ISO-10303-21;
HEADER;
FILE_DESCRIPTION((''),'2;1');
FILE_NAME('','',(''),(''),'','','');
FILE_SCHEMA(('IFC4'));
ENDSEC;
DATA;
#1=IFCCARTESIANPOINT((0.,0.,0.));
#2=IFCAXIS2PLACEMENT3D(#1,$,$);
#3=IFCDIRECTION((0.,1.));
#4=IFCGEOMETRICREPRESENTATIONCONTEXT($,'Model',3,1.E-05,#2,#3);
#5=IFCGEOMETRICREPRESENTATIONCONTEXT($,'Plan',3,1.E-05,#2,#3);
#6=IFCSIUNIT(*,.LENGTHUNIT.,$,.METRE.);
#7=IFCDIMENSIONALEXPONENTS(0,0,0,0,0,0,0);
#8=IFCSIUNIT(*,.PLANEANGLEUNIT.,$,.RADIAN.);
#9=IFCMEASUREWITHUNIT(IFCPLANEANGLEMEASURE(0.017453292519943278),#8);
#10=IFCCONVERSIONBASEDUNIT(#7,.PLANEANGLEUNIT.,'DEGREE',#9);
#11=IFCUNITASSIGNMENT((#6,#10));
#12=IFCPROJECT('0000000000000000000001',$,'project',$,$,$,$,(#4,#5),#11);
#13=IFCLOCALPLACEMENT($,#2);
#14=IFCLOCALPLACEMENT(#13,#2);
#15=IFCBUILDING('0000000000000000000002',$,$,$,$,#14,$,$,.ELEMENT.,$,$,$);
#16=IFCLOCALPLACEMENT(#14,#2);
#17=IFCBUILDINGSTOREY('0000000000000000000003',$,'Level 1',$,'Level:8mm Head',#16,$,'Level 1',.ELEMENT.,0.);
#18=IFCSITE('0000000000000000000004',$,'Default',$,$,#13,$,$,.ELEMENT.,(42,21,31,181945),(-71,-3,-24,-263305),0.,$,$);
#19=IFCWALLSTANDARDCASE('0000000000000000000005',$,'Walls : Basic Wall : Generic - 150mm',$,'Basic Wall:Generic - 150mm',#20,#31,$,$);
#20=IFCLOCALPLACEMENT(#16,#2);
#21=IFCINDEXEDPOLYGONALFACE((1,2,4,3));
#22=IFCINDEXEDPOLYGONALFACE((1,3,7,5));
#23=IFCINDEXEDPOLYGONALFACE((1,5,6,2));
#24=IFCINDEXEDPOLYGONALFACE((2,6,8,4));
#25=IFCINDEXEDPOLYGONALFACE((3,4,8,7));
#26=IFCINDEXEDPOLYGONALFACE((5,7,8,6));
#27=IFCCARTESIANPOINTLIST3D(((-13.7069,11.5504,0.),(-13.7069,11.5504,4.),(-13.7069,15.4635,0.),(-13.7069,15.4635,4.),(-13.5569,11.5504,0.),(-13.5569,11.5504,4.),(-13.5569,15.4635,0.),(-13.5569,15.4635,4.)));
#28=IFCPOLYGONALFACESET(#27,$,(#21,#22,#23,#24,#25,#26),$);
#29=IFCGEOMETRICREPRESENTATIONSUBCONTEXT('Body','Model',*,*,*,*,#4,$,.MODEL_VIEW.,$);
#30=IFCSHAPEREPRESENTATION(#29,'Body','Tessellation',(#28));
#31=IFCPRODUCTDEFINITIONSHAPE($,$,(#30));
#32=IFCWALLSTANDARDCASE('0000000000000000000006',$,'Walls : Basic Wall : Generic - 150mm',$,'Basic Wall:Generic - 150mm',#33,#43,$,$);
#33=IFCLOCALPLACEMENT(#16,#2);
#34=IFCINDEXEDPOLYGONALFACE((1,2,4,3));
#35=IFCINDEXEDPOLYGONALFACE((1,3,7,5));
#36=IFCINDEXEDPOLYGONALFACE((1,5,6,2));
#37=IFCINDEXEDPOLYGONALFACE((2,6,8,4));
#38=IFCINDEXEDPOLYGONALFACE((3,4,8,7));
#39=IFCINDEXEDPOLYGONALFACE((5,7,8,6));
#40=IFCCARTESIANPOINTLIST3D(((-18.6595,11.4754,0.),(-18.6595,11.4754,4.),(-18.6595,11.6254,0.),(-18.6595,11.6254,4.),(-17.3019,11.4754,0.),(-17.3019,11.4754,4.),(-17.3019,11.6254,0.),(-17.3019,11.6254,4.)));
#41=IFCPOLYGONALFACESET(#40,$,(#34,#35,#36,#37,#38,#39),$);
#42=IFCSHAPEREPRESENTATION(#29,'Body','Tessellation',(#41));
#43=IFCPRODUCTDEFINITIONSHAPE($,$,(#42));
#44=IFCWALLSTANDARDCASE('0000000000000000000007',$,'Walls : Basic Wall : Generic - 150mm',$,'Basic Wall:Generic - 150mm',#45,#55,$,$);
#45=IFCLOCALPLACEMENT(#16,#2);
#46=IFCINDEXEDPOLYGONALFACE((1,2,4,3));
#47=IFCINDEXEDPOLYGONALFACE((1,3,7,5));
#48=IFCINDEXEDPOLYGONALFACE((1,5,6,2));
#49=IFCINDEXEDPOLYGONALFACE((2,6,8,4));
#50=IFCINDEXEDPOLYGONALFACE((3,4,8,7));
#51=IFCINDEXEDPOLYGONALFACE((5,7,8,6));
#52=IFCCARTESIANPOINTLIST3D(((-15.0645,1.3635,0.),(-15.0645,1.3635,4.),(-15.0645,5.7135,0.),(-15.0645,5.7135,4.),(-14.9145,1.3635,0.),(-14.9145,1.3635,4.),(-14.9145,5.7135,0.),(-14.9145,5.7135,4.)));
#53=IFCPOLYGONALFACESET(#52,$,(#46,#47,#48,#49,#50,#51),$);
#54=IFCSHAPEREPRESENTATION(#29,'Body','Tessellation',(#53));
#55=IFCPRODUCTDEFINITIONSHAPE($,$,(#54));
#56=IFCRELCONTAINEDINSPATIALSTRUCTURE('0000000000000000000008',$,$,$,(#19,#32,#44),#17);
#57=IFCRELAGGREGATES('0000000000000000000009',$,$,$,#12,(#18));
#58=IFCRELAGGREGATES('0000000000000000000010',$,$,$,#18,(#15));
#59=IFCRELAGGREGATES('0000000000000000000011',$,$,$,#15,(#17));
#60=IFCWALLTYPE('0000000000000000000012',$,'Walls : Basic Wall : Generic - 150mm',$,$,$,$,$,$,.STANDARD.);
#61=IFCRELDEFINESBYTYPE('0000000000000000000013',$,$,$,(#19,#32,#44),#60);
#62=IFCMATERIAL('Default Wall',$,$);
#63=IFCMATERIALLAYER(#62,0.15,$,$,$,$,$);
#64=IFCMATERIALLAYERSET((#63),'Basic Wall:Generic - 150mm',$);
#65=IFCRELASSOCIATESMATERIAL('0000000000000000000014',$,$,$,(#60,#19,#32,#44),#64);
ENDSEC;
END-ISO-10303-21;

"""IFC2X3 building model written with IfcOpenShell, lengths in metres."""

from ifc_helpers import new_model, entity, si_unit, converted_unit, direction, frame, frame_2d, origin, place, context, subcontext, project, spatial, rectangle, extrude, material, layer, layer_set, layer_usage, type_object, element, save


model = new_model("IFC2X3")

# Units and contexts
model_context = context("Model", 3, precision=1e-05, world=origin(), true_north=direction((0.0, 1.0)))
plan_context = context("Plan", 3, precision=1e-05, world=origin(), true_north=direction((0.0, 1.0)))
body_context = subcontext(model_context, "Body", "Model", "MODEL_VIEW")
ifc_project = project(units=[si_unit("LENGTHUNIT", "METRE"), converted_unit("PLANEANGLEUNIT", "DEGREE", entity("IfcPlaneAngleMeasure", 0.017453292519943278), si_unit("PLANEANGLEUNIT", "RADIAN"), dimensions=[0, 0, 0, 0, 0, 0, 0])], contexts=[model_context, plan_context])

# Site, building, storey
site_placement = place(None, origin())
site = spatial("IfcSite", under=ifc_project, at=site_placement, Name="Default", CompositionType="ELEMENT", RefLatitude=(42, 21, 31, 181945), RefLongitude=(-71, -3, -24, -263305), RefElevation=0.0)
building_placement = place(site_placement, origin())
building = spatial("IfcBuilding", under=site, at=building_placement, CompositionType="ELEMENT")
storey_placement = place(building_placement, origin())
storey = spatial("IfcBuildingStorey", under=building, at=storey_placement, Name="Level 1", ObjectType="Level:8mm Head", LongName="Level 1", CompositionType="ELEMENT", Elevation=0.0)

# Walls
ifc_material = material(Name="Default Wall")
ifc_layer_1 = layer(ifc_material, 0.15)
ifc_layer_set_1 = layer_set([ifc_layer_1], Name="Basic Wall:Generic - 150mm")
ifc_layer_usage_1 = layer_usage(ifc_layer_set_1, "AXIS2", "NEGATIVE", 0.075)
wall_type_1 = type_object("IfcWallType", Name="Walls : Basic Wall : Generic - 150mm", PredefinedType="STANDARD", material=ifc_layer_set_1)
wall_1_placement = place(storey_placement, frame((-13.6319, 11.5504, 0.0), z_axis=(0.0, 0.0, 1.0), x_axis=(0.0, 1.0, 0.0)))
element("IfcWallStandardCase", 1, at=wall_1_placement, inside=storey, type_object=wall_type_1, material=ifc_layer_usage_1, Name="Walls : Basic Wall : Generic - 150mm", ObjectType="Basic Wall:Generic - 150mm", context=body_context, shape_type="SweptSolid", body=[
    extrude(rectangle(XDim=3.9131, YDim=0.15, at=frame_2d((1.9565, 0.0), x_axis=(-1.0, 0.0))), origin(), (0.0, 0.0, 1.0), 4.0),
])
wall_2_placement = place(storey_placement, frame((-18.6595, 11.5504, 0.0)))
element("IfcWallStandardCase", 2, at=wall_2_placement, inside=storey, type_object=wall_type_1, material=ifc_layer_usage_1, Name="Walls : Basic Wall : Generic - 150mm", ObjectType="Basic Wall:Generic - 150mm", context=body_context, shape_type="SweptSolid", body=[
    extrude(rectangle(XDim=1.3576, YDim=0.15, at=frame_2d((0.6788, 0.0), x_axis=(-1.0, 0.0))), origin(), (0.0, 0.0, 1.0), 4.0),
])
wall_3_placement = place(storey_placement, frame((-14.9895, 5.7135, 0.0), z_axis=(0.0, 0.0, 1.0), x_axis=(0.0, -1.0, 0.0)))
element("IfcWallStandardCase", 3, at=wall_3_placement, inside=storey, type_object=wall_type_1, material=ifc_layer_usage_1, Name="Walls : Basic Wall : Generic - 150mm", ObjectType="Basic Wall:Generic - 150mm", context=body_context, shape_type="SweptSolid", body=[
    extrude(rectangle(XDim=4.35, YDim=0.15, at=frame_2d((2.175, 0.0), x_axis=(-1.0, 0.0))), origin(), (0.0, 0.0, 1.0), 4.0),
])

save(model, "model.ifc")
